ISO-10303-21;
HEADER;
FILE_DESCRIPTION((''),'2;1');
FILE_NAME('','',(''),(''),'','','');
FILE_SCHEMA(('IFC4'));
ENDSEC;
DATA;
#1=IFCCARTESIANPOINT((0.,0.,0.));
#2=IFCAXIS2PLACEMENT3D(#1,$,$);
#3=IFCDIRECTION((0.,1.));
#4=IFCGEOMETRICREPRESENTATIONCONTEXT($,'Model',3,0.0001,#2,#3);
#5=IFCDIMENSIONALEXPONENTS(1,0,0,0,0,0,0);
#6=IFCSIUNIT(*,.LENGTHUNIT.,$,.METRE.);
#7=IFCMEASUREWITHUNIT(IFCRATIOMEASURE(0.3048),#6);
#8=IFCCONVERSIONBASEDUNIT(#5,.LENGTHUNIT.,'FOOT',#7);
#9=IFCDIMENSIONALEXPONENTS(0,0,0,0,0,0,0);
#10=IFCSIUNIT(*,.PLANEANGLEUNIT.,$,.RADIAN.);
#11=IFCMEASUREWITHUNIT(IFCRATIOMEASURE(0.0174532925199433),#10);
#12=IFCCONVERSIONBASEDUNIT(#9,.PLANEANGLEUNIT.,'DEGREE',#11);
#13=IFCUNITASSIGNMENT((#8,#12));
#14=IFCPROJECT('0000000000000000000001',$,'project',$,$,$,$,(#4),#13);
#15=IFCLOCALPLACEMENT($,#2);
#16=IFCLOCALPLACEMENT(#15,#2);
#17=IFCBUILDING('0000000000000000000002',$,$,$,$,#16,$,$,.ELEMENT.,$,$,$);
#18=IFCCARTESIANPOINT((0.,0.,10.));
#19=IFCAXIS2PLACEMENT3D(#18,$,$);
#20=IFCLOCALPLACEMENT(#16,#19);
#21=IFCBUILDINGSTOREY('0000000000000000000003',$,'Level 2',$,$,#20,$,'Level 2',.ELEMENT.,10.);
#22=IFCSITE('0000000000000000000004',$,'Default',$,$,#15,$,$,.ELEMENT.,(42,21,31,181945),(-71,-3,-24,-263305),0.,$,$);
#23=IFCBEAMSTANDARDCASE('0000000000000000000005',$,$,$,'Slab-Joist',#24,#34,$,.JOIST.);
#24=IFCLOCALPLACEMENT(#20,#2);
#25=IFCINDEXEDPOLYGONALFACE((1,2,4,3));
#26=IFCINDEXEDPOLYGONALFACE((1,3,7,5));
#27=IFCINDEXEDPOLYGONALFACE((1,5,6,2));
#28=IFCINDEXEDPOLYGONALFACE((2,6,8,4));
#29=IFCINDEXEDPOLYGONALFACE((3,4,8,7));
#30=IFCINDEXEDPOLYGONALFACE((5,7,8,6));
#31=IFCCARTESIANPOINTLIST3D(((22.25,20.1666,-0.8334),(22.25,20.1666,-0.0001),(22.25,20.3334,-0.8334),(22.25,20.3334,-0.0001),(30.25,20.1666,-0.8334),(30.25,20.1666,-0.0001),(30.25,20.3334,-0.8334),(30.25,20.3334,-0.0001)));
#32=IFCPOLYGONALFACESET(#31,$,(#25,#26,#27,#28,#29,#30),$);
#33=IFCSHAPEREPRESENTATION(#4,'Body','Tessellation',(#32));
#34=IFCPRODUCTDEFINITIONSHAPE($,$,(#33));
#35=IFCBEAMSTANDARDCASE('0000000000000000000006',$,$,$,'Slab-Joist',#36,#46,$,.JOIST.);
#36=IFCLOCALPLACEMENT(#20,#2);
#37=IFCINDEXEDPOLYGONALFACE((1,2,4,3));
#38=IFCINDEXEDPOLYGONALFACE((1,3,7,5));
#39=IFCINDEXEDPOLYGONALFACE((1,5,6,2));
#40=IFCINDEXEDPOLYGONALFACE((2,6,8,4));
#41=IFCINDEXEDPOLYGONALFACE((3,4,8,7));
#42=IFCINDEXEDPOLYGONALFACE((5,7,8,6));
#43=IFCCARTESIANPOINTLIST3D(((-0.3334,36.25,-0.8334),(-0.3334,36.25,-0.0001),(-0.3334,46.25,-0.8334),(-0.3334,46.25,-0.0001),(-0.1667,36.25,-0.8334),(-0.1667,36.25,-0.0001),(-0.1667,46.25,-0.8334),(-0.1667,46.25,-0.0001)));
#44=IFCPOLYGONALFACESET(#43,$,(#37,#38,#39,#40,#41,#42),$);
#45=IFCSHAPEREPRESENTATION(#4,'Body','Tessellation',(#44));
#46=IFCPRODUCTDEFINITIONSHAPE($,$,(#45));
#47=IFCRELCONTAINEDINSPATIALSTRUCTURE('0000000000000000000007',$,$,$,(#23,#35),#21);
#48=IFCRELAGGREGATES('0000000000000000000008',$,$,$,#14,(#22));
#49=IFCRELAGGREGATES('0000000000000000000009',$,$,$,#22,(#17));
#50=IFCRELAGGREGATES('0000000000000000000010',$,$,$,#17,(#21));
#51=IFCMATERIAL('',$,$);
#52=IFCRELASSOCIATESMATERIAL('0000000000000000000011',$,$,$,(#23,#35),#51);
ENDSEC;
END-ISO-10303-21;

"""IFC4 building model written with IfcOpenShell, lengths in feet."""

from ifc_helpers import new_model, entity, si_unit, converted_unit, direction, frame, origin, origin_with_axes, place, context, project, spatial, rectangle, extrude, material, element, save


model = new_model("IFC4")

# Units and contexts
model_context = context("Model", 3, precision=0.0001, world=origin(), true_north=direction((0.0, 1.0)))
ifc_project = project(units=[converted_unit("LENGTHUNIT", "FOOT", entity("IfcRatioMeasure", 0.3048), si_unit("LENGTHUNIT", "METRE"), dimensions=[1, 0, 0, 0, 0, 0, 0]), converted_unit("PLANEANGLEUNIT", "DEGREE", entity("IfcRatioMeasure", 0.0174532925199433), si_unit("PLANEANGLEUNIT", "RADIAN"), dimensions=[0, 0, 0, 0, 0, 0, 0])], contexts=[model_context])

# Site, building, storey
site_placement = place(None, origin())
site = spatial("IfcSite", under=ifc_project, at=site_placement, Name="Default", CompositionType="ELEMENT", RefLatitude=(42, 21, 31, 181945), RefLongitude=(-71, -3, -24, -263305), RefElevation=0.0)
building_placement = place(site_placement, origin())
building = spatial("IfcBuilding", under=site, at=building_placement, CompositionType="ELEMENT")
storey_placement = place(building_placement, frame((0.0, 0.0, 10.0)))
storey = spatial("IfcBuildingStorey", under=building, at=storey_placement, Name="Level 2", LongName="Level 2", CompositionType="ELEMENT", Elevation=10.0)

# Beams
ifc_material = material(Name="")
placement_1 = place(storey_placement, frame((22.25, 20.25, 0.0), z_axis=(0.0, 0.0, 1.0), x_axis=(1.0, 0.0, 0.0)))
beam_1_placement = place(placement_1, frame((0.0, 0.0, -0.4167), z_axis=(1.0, 0.0, 0.0), x_axis=(0.0, 1.0, 0.0)))
element("IfcBeamStandardCase", 1, at=beam_1_placement, inside=storey, material=ifc_material, ObjectType="Slab-Joist", PredefinedType="JOIST", context=model_context, shape_type="SweptSolid", body=[
    extrude(rectangle(XDim=0.1667, YDim=0.8333), origin_with_axes(), (0.0, 0.0, 1.0), 8.0),
])
placement_2 = place(storey_placement, frame((-0.25, 36.25, 0.0), z_axis=(0.0, 0.0, 1.0), x_axis=(1.0, 0.0, 0.0)))
beam_2_placement = place(placement_2, frame((0.0, 0.0, -0.4167), z_axis=(0.0, 1.0, 0.0), x_axis=(-1.0, 0.0, 0.0)))
element("IfcBeamStandardCase", 2, at=beam_2_placement, inside=storey, material=ifc_material, ObjectType="Slab-Joist", PredefinedType="JOIST", context=model_context, shape_type="SweptSolid", body=[
    extrude(rectangle(XDim=0.1667, YDim=0.8333), origin_with_axes(), (0.0, 0.0, 1.0), 10.0),
])

save(model, "model.ifc")
